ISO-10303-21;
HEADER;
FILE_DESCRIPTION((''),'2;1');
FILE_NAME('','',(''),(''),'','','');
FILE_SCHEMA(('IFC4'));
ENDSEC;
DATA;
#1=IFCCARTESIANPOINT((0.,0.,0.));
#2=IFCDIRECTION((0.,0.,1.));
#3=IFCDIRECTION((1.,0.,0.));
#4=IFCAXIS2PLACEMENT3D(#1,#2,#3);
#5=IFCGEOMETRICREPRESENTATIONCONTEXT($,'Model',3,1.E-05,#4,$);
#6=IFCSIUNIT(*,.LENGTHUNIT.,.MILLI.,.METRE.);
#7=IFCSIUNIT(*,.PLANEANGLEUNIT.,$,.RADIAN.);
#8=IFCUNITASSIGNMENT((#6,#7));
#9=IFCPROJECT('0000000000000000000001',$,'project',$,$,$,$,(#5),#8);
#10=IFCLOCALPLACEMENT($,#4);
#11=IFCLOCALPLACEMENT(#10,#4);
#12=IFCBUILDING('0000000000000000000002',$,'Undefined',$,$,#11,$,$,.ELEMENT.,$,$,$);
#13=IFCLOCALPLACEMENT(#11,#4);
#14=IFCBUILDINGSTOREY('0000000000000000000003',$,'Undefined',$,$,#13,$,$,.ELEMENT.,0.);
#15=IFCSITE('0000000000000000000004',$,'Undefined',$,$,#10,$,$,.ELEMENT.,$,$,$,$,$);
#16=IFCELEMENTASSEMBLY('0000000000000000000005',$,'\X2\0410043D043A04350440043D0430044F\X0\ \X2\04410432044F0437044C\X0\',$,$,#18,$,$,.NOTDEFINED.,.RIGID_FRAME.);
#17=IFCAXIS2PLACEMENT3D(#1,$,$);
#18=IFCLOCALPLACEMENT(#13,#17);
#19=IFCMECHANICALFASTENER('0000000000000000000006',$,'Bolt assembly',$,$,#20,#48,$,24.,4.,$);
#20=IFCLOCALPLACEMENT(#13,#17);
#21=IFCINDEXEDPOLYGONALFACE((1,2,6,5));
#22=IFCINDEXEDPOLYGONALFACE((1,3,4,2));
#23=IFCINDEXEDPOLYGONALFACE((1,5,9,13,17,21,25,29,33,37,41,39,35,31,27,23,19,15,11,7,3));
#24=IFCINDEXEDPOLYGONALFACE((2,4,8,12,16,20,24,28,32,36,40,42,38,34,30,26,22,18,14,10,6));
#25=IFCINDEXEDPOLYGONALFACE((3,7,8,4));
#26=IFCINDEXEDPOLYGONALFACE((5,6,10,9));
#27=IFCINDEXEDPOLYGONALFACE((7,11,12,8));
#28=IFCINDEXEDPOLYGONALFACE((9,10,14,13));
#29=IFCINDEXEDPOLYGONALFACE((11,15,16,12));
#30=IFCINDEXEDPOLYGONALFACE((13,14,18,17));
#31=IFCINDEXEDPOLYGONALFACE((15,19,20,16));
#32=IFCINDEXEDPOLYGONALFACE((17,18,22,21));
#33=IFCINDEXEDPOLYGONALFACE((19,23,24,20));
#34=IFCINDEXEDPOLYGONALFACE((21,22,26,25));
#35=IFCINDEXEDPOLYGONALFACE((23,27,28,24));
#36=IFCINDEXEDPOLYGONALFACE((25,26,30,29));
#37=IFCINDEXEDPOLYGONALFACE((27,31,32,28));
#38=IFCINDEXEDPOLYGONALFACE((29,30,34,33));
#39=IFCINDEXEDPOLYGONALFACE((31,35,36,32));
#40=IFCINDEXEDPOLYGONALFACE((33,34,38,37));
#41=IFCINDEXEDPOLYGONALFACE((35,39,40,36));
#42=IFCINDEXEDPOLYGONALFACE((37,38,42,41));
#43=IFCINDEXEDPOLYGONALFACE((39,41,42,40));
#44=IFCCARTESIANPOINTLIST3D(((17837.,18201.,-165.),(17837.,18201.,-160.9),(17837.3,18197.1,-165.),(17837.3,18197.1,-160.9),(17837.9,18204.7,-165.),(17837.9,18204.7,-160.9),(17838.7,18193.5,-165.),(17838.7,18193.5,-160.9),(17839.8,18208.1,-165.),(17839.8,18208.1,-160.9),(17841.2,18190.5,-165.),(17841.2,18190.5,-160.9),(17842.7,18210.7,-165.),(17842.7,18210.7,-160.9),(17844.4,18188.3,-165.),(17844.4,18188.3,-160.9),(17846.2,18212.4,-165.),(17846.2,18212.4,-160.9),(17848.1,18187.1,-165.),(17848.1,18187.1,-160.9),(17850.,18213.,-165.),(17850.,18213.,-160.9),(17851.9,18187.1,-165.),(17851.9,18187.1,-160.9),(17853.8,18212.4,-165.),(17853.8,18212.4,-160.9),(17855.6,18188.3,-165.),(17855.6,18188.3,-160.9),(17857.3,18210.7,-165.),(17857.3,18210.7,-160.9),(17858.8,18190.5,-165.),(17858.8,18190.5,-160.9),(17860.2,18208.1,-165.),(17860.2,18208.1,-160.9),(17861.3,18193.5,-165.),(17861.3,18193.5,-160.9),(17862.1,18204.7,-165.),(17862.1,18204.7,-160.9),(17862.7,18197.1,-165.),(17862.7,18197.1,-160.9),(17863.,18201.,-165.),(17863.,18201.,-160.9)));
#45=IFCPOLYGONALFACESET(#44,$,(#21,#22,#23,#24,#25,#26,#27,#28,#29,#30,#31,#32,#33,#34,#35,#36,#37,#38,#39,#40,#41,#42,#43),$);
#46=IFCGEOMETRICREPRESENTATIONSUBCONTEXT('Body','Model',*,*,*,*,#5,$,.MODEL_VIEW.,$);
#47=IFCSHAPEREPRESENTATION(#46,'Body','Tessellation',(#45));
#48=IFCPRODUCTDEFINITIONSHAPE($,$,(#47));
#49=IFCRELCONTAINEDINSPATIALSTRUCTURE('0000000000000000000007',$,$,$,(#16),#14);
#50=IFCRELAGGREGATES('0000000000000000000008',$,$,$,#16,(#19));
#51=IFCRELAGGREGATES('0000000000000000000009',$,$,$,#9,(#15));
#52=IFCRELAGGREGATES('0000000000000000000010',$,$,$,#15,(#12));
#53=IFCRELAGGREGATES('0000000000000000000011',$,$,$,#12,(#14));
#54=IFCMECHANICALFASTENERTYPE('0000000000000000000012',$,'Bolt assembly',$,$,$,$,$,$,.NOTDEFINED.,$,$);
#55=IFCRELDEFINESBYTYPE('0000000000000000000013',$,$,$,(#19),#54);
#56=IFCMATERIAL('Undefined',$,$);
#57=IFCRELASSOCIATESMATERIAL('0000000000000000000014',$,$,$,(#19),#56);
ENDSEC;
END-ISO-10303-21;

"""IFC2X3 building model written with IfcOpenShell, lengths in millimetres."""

from ifc_helpers import new_model, si_unit, frame, origin_with_axes, origin_2d_with_axis, place, context, subcontext, project, spatial, circle, extrude, source, transform, mapped, material, type_object, element, aggregate, save


model = new_model("IFC2X3")

# Units and contexts
model_context = context("Model", 3, precision=1e-05, world=origin_with_axes())
body_context = subcontext(model_context, "Body", "Model", "MODEL_VIEW")
ifc_project = project(units=[si_unit("LENGTHUNIT", "METRE", prefix="MILLI"), si_unit("PLANEANGLEUNIT", "RADIAN")], contexts=[model_context])

# Site, building, storey
site_placement = place(None, origin_with_axes())
site = spatial("IfcSite", under=ifc_project, at=site_placement, Name="Undefined", CompositionType="ELEMENT")
building_placement = place(site_placement, origin_with_axes())
building = spatial("IfcBuilding", under=site, at=building_placement, Name="Undefined", CompositionType="ELEMENT")
storey_placement = place(building_placement, origin_with_axes())
storey = spatial("IfcBuildingStorey", under=building, at=storey_placement, Name="Undefined", CompositionType="ELEMENT", Elevation=0.0)

# Element assembly
assembly_1_placement = place(storey_placement, origin_with_axes())
assembly_1 = element("IfcElementAssembly", 1, at=assembly_1_placement, inside=storey, Name="Анкерная связь", AssemblyPlace="NOTDEFINED", PredefinedType="RIGID_FRAME")

# Mechanical fastener
ifc_material_1 = material(Name="Undefined")
mechanical_fastener_type = type_object("IfcMechanicalFastenerType", Name="Bolt assembly")
shared_shape_1 = source(origin_with_axes(), body_context, "Body", "SweptSolid", [
    extrude(circle(Radius=13.0, at=origin_2d_with_axis()), frame((0.0, -4.0, 0.0), z_axis=(0.0, 1.0, 0.0), x_axis=(1.0, 0.0, 0.0)), (0.0, 0.0, 1.0), 4.1),
])
mechanical_fastener_1_placement = place(assembly_1_placement, frame((17850.0, 18200.0, -161.0), z_axis=(1.0, 0.0, 0.0), x_axis=(0.0, 1.0, 0.0)))
mechanical_fastener_1 = element("IfcMechanicalFastener", 2, at=mechanical_fastener_1_placement, type_object=mechanical_fastener_type, material=ifc_material_1, Name="Bolt assembly", NominalDiameter=24.0, NominalLength=4.0, context=body_context, shape_type="MappedRepresentation", body=[
    mapped(shared_shape_1, transform((0.0, 0.0, 0.0))),
])
aggregate(assembly_1, [mechanical_fastener_1])

save(model, "model.ifc")
